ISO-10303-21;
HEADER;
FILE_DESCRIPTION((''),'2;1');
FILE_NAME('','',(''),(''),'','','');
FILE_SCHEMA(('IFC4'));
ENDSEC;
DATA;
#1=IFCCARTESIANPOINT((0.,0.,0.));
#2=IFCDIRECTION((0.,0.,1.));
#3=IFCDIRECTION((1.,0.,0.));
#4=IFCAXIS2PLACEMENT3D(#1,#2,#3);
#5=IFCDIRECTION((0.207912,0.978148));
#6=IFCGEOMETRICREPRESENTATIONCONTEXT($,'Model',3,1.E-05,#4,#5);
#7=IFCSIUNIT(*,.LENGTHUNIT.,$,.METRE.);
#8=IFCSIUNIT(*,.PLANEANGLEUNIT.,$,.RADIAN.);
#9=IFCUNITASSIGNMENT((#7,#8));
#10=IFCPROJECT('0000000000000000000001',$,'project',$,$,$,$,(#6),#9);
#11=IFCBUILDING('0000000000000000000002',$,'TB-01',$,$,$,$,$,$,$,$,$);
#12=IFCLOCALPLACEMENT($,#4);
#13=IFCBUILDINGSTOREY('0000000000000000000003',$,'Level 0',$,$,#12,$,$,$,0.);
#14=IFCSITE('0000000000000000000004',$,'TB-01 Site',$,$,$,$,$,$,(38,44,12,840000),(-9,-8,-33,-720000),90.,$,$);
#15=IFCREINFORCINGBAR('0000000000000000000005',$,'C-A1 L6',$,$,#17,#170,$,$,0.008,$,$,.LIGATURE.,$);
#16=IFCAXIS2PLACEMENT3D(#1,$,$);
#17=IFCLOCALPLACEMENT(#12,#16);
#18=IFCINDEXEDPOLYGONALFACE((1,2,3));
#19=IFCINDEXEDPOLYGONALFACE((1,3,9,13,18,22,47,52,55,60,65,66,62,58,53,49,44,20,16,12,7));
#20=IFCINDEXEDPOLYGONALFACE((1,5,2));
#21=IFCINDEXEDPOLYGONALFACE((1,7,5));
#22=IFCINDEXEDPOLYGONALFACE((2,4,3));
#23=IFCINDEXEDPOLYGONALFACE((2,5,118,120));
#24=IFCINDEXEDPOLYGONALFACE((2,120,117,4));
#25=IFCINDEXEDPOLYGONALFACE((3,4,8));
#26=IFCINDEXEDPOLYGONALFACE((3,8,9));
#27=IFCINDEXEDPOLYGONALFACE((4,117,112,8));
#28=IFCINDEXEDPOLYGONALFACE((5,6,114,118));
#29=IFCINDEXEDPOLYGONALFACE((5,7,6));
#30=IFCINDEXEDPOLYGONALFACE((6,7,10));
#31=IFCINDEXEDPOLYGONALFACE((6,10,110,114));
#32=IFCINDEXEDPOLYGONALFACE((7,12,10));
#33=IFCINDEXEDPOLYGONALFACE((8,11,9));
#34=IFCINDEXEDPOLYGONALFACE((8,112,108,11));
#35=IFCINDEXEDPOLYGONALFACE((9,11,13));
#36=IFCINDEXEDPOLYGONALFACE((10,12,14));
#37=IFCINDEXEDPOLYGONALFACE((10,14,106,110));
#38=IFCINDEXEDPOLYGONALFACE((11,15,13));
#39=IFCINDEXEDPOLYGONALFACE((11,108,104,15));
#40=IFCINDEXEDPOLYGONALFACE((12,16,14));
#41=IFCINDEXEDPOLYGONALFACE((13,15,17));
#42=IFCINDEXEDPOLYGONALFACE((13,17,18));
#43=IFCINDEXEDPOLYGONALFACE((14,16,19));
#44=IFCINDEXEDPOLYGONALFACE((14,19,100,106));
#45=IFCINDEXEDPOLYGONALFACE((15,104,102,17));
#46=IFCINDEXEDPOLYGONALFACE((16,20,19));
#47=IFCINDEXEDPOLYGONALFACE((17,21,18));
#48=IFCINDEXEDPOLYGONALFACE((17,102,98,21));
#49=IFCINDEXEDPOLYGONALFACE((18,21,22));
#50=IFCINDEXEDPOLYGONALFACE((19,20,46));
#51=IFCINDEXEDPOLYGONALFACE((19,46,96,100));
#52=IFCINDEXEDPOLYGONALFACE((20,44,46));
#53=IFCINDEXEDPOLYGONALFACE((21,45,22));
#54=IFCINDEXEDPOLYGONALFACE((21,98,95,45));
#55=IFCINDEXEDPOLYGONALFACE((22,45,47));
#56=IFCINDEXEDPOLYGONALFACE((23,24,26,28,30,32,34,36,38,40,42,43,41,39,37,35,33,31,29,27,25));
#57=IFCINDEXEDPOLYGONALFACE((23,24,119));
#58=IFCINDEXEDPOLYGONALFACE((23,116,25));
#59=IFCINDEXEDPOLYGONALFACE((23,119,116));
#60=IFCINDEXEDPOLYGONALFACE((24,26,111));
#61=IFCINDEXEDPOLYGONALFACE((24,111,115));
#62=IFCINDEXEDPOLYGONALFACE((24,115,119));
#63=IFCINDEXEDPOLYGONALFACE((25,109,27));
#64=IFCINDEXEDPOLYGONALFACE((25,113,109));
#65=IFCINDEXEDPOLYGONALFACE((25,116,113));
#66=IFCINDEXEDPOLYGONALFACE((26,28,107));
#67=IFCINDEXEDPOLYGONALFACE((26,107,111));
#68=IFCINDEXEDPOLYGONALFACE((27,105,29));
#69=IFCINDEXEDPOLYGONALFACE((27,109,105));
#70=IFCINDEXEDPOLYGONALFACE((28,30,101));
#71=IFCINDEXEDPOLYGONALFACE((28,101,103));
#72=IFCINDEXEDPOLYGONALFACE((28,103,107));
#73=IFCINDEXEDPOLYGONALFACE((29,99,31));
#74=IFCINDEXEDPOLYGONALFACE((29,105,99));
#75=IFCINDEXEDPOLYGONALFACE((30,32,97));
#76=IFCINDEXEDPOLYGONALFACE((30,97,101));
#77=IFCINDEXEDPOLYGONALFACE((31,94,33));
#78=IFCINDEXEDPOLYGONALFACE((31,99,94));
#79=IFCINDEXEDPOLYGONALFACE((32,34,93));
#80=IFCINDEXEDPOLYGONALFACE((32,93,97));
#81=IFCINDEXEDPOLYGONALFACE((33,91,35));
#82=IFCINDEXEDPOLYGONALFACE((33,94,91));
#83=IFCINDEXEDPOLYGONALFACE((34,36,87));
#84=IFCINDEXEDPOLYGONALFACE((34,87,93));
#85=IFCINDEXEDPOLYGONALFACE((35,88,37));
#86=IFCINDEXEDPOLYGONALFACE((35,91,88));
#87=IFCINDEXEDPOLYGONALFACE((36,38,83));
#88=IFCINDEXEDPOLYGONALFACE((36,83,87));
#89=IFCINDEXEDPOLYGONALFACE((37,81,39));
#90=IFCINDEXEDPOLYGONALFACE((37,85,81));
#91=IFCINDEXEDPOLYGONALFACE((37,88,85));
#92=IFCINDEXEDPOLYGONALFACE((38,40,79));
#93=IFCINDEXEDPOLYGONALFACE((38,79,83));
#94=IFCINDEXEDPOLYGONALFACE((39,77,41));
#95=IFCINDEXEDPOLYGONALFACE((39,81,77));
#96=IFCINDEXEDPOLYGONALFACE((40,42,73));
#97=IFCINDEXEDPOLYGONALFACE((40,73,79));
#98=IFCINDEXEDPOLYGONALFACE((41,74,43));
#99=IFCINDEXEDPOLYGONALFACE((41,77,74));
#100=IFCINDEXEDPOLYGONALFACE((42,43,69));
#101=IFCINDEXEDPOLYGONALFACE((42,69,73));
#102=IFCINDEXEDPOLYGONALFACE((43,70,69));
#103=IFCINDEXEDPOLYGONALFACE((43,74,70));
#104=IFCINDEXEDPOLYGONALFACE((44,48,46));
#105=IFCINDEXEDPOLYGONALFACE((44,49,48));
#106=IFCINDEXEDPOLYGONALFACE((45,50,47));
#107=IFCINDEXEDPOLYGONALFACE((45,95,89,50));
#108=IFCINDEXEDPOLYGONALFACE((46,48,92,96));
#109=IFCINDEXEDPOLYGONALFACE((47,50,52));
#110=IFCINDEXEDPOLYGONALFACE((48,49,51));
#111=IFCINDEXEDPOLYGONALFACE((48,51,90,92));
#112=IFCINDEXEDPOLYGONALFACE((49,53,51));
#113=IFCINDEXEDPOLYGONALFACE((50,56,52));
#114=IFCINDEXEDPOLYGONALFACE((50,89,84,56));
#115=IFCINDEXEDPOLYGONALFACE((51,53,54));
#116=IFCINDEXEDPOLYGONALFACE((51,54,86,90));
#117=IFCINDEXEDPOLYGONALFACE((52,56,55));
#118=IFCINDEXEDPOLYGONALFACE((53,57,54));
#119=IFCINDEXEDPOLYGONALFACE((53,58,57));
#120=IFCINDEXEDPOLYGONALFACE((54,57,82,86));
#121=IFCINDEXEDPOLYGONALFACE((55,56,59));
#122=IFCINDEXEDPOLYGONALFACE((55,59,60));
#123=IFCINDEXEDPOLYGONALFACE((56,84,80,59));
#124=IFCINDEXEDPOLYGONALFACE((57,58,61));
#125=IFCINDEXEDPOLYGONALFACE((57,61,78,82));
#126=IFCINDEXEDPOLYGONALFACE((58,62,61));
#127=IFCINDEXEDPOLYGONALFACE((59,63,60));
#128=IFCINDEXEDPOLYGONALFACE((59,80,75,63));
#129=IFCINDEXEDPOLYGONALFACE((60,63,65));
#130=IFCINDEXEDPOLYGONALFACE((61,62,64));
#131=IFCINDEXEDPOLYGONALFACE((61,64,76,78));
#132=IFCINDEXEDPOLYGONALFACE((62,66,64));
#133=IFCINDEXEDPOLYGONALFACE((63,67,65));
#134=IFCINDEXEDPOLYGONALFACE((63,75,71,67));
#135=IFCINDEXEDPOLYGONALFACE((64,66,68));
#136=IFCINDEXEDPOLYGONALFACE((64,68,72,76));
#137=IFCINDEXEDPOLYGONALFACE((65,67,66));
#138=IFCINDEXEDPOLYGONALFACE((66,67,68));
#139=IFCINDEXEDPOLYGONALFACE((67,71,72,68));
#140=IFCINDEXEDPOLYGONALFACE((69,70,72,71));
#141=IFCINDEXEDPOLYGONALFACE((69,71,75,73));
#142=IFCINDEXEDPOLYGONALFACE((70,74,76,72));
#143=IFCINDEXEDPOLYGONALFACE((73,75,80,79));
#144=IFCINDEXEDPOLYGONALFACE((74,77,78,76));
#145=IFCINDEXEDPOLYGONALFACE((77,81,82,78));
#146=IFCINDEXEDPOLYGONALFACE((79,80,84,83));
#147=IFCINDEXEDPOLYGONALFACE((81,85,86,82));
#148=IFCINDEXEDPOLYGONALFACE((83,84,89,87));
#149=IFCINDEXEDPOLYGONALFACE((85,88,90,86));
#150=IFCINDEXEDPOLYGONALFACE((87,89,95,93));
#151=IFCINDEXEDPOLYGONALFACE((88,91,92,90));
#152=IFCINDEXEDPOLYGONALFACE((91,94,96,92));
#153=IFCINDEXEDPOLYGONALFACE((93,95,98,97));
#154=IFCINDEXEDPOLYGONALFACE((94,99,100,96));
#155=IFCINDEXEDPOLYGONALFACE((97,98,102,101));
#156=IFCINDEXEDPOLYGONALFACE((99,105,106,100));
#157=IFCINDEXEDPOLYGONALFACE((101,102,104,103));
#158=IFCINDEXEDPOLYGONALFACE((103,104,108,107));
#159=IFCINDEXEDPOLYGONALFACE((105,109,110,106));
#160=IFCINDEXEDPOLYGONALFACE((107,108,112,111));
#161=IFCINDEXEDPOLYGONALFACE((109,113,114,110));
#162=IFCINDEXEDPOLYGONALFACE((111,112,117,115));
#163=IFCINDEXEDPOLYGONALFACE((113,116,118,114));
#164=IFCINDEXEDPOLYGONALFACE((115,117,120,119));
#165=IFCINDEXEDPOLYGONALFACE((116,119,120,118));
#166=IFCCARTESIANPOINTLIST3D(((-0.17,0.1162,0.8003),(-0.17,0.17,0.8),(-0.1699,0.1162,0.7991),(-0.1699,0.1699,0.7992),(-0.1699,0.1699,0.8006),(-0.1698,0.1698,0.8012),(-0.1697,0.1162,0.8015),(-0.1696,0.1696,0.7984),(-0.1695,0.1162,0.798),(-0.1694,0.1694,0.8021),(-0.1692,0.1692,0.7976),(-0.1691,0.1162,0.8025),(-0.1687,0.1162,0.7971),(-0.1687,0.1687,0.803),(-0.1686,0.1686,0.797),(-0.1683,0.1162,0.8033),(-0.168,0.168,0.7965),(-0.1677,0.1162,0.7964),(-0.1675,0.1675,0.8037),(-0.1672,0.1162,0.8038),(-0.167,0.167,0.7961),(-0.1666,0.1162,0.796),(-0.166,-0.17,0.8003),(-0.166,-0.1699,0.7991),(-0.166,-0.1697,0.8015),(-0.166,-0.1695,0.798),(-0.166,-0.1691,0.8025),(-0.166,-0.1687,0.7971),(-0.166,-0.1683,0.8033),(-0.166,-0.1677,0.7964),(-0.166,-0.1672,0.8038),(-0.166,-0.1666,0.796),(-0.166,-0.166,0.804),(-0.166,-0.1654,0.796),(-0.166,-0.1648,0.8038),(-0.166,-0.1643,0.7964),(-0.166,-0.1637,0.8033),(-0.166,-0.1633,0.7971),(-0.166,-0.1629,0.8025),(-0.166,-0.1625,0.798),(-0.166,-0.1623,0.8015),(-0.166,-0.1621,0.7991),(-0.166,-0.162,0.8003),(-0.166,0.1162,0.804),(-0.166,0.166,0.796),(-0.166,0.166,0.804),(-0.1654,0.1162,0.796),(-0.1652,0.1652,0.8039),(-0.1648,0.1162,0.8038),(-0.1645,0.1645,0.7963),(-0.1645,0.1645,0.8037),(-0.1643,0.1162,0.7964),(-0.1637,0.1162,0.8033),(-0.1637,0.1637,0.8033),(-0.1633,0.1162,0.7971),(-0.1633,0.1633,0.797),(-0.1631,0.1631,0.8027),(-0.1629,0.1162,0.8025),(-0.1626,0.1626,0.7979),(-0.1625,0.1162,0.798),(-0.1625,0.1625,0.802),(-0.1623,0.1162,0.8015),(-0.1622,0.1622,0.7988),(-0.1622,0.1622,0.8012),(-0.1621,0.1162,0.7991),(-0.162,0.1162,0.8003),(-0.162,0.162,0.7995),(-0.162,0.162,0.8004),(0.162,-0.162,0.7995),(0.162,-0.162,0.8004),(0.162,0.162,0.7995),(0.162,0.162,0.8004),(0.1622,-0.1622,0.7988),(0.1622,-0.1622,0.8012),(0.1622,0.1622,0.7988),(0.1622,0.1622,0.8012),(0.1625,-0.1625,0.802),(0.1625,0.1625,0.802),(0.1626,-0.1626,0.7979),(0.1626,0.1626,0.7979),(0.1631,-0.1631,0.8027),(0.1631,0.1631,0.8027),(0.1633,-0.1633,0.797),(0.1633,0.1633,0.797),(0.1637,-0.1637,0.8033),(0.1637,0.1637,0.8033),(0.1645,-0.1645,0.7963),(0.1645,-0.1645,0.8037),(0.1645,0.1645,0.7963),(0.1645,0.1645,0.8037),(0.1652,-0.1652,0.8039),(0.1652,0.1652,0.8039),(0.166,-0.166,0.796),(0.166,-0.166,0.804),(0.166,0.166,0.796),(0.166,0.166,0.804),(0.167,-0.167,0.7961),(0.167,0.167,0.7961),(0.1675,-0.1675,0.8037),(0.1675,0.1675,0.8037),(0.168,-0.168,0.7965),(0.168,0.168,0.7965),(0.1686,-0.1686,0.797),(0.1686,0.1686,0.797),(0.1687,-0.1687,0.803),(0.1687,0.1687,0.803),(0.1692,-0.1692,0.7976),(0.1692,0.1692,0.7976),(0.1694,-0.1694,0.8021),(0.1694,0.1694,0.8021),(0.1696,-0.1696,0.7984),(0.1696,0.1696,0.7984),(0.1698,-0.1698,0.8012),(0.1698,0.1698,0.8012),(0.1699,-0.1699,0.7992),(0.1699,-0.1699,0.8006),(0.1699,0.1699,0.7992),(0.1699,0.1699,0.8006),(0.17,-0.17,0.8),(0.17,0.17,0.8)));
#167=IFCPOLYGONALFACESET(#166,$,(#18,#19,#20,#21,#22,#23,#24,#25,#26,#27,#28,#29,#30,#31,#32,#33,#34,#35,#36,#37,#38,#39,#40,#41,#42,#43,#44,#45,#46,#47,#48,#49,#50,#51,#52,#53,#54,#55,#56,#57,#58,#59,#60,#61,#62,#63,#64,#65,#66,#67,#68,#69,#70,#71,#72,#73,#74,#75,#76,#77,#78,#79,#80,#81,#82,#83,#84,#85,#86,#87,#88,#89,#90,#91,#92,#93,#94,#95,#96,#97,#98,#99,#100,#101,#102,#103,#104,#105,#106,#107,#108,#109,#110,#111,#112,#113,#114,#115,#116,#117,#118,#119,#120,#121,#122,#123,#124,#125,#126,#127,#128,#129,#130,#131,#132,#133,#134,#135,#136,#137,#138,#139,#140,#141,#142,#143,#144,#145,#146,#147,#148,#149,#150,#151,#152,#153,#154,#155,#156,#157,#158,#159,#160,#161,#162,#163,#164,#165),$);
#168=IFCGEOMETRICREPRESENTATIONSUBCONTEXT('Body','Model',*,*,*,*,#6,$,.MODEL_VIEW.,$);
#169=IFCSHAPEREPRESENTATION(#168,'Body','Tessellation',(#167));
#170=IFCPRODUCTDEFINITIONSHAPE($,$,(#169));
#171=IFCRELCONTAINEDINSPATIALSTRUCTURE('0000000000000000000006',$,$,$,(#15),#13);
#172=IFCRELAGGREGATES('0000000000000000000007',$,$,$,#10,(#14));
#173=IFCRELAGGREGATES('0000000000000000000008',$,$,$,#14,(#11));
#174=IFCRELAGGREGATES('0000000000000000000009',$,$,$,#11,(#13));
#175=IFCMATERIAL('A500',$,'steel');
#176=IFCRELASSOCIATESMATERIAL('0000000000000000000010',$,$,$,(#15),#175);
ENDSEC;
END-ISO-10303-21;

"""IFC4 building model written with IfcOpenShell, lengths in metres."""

from ifc_helpers import new_model, entity, si_unit, direction, origin_with_axes, place, context, subcontext, project, spatial, material, element, save


model = new_model("IFC4")

# Units and contexts
model_context = context("Model", 3, precision=1e-05, world=origin_with_axes(), true_north=direction((0.207912, 0.978148)))
body_context = subcontext(model_context, "Body", "Model", "MODEL_VIEW")
ifc_project = project(units=[si_unit("LENGTHUNIT", "METRE"), si_unit("PLANEANGLEUNIT", "RADIAN")], contexts=[model_context])

# Site, building, storey
site = spatial("IfcSite", under=ifc_project, Name="TB-01 Site", RefLatitude=(38, 44, 12, 840000), RefLongitude=(-9, -8, -33, -720000), RefElevation=90.0)
building = spatial("IfcBuilding", under=site, Name="TB-01")
storey_placement = place(None, origin_with_axes())
storey = spatial("IfcBuildingStorey", under=building, at=storey_placement, Name="Level 0", Elevation=0.0)

# Reinforcing bar
ifc_material_1 = material(Name="A500", Category="steel")
reinforcing_bar_1_placement = place(storey_placement, origin_with_axes())
element("IfcReinforcingBar", 1, at=reinforcing_bar_1_placement, inside=storey, material=ifc_material_1, Name="C-A1 L6", NominalDiameter=0.008, PredefinedType="LIGATURE", context=body_context, shape_type="AdvancedSweptSolid", body=[
    entity("IfcSweptDiskSolid", entity("IfcPolyline", [entity("IfcCartesianPoint", [-0.166, -0.166, 0.8]), entity("IfcCartesianPoint", [0.166, -0.166, 0.8]), entity("IfcCartesianPoint", [0.166, 0.166, 0.8]), entity("IfcCartesianPoint", [-0.166, 0.166, 0.8]), entity("IfcCartesianPoint", [-0.166, 0.1162, 0.8])]), 0.004),
])

save(model, "model.ifc")
